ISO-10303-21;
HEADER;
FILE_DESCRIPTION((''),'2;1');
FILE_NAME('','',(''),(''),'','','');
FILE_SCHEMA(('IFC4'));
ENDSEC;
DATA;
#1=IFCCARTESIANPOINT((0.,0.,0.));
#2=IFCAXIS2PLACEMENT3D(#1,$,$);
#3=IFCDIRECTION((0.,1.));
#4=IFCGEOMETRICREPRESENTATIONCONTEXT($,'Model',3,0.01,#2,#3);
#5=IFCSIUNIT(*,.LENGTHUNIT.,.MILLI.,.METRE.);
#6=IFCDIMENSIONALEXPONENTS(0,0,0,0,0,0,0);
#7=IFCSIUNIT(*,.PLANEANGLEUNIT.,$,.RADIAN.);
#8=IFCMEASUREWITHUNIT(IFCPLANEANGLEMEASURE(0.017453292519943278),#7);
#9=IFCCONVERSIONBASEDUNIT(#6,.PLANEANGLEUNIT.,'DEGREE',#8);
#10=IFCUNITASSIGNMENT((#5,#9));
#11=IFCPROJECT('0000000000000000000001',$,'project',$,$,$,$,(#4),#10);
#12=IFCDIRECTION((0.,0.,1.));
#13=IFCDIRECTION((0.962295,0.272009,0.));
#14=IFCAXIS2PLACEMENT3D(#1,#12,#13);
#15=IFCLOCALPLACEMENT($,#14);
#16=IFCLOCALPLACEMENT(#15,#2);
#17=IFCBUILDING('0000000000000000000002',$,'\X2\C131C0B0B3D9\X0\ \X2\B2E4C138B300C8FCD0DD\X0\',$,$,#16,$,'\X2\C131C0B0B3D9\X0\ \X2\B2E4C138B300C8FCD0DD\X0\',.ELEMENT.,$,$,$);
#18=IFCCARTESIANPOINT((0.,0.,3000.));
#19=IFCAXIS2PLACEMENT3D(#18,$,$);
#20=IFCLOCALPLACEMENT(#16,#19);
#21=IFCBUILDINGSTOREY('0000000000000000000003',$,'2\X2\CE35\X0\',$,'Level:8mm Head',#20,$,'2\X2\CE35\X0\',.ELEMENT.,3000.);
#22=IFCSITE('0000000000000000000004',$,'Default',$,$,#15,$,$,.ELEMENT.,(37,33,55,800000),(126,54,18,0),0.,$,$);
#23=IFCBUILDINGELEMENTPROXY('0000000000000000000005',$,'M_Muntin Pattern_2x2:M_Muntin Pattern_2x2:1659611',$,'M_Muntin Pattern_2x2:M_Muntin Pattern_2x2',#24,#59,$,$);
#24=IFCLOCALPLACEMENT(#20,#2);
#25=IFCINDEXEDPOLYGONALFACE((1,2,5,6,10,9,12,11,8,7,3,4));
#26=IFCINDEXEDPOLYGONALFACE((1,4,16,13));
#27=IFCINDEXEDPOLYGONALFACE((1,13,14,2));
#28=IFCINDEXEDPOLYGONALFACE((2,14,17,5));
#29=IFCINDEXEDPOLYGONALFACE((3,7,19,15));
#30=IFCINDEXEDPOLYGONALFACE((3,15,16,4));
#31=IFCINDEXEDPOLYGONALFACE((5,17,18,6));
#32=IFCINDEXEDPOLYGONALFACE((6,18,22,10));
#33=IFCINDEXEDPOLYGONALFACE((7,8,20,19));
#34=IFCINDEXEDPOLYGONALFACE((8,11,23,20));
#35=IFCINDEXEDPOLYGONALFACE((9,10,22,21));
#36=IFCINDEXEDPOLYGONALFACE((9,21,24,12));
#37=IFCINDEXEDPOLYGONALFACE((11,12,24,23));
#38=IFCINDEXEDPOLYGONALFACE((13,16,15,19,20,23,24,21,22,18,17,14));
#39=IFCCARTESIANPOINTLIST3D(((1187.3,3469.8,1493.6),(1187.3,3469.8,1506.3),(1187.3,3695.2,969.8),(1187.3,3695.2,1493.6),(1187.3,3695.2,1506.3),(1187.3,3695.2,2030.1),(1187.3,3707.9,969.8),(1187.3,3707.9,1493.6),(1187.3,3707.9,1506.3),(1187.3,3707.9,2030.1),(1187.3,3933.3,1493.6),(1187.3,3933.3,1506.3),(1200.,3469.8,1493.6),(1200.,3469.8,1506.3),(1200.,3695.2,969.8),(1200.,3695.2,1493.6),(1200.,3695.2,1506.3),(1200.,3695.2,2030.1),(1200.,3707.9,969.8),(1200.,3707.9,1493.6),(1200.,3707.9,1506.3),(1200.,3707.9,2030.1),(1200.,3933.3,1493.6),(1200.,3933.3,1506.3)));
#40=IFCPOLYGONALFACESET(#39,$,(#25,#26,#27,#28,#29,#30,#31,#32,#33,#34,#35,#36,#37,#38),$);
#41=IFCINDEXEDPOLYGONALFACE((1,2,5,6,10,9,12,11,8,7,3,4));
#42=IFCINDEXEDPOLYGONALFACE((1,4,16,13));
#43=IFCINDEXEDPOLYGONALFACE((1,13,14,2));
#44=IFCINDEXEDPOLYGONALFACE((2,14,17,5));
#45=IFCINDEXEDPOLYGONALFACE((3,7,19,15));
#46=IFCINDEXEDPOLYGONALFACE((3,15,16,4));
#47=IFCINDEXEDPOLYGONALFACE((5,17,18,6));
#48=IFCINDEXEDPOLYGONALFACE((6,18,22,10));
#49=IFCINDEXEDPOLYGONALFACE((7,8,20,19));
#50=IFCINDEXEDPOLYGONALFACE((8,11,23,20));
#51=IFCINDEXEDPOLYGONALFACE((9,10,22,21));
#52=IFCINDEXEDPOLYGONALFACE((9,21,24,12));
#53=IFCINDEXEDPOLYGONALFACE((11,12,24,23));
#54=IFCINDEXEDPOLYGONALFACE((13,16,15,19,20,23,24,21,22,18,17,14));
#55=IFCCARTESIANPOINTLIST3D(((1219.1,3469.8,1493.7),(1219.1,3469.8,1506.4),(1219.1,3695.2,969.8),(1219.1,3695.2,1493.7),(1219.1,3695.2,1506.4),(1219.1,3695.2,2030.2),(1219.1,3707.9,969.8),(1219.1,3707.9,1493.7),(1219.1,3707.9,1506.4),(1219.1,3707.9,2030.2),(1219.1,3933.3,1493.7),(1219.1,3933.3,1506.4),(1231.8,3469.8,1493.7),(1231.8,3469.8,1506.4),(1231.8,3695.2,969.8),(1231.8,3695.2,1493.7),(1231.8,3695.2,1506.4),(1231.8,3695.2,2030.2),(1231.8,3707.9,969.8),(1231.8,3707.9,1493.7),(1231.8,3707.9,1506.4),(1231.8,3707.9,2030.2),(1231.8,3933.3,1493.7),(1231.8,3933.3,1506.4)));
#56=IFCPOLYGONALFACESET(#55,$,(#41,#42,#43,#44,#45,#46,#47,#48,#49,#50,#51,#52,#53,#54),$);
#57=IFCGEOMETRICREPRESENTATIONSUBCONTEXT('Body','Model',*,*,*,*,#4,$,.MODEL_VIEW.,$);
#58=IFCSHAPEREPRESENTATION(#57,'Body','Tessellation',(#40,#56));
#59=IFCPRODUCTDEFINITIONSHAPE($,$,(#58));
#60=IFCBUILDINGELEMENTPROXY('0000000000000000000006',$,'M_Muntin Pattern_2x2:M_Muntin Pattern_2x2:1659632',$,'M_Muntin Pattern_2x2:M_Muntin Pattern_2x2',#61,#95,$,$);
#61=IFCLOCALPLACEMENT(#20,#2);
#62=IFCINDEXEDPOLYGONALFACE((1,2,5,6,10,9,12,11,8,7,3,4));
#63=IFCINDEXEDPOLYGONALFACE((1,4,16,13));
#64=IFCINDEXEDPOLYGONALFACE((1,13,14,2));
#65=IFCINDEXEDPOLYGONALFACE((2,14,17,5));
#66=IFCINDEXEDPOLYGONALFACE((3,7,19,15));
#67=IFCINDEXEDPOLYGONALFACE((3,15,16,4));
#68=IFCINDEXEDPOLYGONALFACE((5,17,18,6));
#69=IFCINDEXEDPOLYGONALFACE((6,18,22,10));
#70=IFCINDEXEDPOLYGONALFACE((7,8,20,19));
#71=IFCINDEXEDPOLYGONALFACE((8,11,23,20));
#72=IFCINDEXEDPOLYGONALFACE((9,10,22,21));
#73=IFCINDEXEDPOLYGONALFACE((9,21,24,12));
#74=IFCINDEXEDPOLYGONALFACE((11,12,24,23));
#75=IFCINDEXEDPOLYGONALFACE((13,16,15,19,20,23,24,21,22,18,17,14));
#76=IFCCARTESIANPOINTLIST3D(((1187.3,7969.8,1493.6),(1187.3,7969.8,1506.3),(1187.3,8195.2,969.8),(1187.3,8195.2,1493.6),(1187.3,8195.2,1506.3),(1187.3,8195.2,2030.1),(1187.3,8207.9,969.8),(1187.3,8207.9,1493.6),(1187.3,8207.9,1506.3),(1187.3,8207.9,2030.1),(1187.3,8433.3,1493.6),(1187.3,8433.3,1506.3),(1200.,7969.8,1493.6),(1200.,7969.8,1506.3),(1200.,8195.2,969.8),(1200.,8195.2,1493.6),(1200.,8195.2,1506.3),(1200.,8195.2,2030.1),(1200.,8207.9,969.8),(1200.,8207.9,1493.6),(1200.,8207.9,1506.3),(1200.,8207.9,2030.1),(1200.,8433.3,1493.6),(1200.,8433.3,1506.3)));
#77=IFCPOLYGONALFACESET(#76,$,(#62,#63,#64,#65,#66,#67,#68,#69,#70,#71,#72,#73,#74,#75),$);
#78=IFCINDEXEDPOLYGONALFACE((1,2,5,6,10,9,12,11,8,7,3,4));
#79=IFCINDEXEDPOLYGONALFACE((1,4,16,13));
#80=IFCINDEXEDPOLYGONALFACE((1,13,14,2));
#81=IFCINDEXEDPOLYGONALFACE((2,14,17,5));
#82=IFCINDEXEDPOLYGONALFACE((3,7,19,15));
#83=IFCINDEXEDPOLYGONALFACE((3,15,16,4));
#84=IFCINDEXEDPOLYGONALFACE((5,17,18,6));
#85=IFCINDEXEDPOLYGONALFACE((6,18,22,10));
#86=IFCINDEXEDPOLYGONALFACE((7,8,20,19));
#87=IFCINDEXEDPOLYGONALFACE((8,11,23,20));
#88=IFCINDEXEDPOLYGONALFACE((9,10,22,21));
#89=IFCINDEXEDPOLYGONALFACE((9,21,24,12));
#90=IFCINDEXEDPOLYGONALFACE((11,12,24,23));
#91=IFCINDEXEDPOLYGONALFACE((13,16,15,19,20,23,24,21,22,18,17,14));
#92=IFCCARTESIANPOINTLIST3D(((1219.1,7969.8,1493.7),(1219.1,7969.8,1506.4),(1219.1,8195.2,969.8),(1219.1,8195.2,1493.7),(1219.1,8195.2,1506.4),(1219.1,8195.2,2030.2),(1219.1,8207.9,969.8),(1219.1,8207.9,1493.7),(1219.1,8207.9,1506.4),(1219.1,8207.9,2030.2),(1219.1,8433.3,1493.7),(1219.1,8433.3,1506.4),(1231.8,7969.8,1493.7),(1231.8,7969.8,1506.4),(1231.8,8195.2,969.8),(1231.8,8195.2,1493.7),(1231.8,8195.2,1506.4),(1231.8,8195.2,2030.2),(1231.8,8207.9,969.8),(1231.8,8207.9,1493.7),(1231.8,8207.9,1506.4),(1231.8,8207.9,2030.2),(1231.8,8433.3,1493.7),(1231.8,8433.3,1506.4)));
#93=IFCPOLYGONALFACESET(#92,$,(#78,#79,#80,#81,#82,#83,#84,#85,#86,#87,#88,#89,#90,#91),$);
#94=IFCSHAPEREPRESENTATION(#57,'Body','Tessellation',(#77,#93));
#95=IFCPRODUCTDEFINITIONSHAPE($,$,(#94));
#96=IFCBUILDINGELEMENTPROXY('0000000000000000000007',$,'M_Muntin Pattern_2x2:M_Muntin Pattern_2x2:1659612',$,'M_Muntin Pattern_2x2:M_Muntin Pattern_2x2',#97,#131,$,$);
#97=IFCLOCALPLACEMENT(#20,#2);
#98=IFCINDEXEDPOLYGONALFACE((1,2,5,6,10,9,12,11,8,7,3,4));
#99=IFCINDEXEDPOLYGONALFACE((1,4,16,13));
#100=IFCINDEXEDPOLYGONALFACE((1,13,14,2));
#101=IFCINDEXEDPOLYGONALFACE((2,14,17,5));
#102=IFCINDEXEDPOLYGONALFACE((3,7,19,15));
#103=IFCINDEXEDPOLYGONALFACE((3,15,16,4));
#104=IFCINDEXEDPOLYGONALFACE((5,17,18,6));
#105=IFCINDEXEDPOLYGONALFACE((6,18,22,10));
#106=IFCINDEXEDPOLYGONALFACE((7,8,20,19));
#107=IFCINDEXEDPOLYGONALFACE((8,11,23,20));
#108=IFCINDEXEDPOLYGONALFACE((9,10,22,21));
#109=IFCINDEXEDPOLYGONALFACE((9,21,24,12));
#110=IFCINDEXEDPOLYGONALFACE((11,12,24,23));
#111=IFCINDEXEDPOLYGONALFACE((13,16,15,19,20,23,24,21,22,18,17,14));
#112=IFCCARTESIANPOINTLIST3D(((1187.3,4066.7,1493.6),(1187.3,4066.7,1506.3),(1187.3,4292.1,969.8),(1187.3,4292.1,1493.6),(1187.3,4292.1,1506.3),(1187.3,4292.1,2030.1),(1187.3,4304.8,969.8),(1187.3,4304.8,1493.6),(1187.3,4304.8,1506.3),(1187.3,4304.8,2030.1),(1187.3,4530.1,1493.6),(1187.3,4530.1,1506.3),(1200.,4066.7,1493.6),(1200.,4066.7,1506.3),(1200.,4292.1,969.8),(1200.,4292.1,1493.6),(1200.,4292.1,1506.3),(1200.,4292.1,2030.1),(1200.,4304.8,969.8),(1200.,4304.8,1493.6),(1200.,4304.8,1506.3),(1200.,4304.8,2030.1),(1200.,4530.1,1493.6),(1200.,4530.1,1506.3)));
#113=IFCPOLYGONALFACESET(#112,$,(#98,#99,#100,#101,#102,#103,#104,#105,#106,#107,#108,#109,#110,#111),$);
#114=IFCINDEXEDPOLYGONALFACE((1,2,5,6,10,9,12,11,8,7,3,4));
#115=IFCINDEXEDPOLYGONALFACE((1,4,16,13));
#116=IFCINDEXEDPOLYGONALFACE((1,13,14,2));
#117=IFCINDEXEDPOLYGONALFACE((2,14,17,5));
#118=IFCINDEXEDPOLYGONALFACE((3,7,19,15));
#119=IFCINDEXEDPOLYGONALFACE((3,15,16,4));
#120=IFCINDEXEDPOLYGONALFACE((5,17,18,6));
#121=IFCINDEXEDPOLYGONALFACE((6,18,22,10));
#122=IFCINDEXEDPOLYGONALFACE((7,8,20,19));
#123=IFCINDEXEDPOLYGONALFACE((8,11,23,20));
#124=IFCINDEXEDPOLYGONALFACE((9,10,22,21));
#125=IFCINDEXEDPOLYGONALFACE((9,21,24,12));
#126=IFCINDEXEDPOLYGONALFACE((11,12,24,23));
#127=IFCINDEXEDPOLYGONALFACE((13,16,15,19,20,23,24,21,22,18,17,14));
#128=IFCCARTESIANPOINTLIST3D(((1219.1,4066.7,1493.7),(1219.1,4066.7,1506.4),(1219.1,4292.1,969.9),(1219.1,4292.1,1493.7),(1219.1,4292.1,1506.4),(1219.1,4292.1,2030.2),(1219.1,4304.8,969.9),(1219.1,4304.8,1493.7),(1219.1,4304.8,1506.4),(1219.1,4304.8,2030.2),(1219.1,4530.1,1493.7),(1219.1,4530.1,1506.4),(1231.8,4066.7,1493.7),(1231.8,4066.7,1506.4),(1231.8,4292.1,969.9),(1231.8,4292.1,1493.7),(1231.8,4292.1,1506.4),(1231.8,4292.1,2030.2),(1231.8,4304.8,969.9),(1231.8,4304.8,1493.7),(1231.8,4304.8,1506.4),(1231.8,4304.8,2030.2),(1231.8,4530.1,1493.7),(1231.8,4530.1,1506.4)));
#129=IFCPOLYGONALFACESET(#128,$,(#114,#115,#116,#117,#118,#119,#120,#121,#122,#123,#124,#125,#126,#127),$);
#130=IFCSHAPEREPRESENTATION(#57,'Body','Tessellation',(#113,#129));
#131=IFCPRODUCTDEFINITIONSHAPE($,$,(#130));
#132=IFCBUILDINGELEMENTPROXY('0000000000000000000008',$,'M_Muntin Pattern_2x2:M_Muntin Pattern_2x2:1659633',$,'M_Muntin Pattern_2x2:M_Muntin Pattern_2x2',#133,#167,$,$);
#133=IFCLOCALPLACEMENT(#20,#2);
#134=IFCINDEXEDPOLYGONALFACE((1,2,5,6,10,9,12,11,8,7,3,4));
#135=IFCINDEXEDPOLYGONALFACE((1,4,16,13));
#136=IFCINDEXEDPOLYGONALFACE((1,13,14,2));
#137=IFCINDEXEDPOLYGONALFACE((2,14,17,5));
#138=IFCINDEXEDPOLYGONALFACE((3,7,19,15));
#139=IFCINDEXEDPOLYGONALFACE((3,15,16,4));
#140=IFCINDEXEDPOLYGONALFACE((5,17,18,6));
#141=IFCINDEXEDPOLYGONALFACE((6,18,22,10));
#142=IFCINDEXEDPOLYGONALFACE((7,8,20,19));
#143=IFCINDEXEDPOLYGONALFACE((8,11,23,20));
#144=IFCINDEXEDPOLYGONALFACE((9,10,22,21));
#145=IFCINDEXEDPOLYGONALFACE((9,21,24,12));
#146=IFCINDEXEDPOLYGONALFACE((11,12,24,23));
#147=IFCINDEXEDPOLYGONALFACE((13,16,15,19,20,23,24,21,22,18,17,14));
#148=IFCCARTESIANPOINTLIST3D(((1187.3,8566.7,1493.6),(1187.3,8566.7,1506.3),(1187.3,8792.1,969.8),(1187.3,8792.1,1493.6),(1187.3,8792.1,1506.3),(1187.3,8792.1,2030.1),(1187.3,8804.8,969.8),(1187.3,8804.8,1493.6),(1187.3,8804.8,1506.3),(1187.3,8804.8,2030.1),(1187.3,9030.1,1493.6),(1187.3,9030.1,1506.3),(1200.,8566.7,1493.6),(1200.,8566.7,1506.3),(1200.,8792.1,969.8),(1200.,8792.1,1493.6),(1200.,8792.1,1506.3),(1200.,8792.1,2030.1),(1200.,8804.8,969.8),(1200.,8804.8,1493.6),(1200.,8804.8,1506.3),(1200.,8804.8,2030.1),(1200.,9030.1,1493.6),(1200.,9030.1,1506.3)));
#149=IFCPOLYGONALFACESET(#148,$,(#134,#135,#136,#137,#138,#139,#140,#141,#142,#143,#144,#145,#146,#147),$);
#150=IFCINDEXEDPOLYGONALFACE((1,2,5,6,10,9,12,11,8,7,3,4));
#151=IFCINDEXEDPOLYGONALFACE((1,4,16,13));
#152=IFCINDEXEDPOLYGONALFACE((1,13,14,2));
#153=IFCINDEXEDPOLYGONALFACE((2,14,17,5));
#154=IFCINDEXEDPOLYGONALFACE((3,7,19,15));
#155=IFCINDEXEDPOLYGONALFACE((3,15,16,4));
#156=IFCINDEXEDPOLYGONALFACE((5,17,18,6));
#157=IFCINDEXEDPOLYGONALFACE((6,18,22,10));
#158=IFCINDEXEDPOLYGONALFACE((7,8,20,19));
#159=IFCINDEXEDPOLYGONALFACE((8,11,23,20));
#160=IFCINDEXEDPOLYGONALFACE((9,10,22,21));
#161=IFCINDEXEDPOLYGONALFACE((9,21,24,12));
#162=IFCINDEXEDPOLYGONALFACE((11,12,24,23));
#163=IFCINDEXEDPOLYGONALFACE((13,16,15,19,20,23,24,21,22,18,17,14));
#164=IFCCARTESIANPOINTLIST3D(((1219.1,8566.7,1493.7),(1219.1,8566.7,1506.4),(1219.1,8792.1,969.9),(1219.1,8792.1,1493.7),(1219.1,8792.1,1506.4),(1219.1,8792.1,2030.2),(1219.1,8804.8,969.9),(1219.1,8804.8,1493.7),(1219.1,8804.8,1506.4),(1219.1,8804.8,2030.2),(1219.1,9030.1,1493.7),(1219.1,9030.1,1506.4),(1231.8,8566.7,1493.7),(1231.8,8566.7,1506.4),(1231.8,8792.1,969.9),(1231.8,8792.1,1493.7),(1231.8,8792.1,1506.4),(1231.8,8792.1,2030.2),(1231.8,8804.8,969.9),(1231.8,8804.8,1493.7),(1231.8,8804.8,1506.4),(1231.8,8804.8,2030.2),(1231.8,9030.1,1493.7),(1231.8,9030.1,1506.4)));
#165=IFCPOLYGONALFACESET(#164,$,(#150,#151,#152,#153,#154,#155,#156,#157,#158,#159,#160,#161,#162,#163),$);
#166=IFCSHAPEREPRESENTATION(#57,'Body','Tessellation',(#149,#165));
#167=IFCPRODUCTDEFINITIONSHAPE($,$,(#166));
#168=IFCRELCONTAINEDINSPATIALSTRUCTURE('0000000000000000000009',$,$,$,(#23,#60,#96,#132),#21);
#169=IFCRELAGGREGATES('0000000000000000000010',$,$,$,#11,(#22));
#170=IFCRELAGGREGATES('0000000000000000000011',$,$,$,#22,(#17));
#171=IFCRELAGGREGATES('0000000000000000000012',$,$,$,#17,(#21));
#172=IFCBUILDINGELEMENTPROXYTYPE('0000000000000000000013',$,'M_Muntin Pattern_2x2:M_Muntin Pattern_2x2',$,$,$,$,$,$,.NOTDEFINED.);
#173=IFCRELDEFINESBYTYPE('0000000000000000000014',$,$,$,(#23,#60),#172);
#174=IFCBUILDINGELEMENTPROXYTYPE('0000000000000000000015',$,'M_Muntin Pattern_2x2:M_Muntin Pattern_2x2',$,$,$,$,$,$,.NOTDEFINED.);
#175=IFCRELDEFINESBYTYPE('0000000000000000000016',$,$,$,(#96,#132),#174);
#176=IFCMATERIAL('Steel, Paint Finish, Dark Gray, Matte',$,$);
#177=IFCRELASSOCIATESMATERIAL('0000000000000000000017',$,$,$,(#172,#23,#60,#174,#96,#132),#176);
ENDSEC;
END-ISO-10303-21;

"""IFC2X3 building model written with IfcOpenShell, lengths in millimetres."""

from ifc_helpers import new_model, entity, si_unit, converted_unit, direction, frame, origin, place, context, subcontext, project, spatial, polyline, outline, extrude, source, transform, mapped, material, type_object, type_shapes, element, save


model = new_model("IFC2X3")

# Units and contexts
model_context = context("Model", 3, precision=0.01, world=origin(), true_north=direction((0.0, 1.0)))
body_context = subcontext(model_context, "Body", "Model", "MODEL_VIEW")
ifc_project = project(units=[si_unit("LENGTHUNIT", "METRE", prefix="MILLI"), converted_unit("PLANEANGLEUNIT", "DEGREE", entity("IfcPlaneAngleMeasure", 0.017453292519943278), si_unit("PLANEANGLEUNIT", "RADIAN"), dimensions=[0, 0, 0, 0, 0, 0, 0])], contexts=[model_context])

# Site, building, storey
site_placement = place(None, frame((0.0, 0.0, 0.0), z_axis=(0.0, 0.0, 1.0), x_axis=(0.962295, 0.272009, 0.0)))
site = spatial("IfcSite", under=ifc_project, at=site_placement, Name="Default", CompositionType="ELEMENT", RefLatitude=(37, 33, 55, 800000), RefLongitude=(126, 54, 18, 0), RefElevation=0.0)
building_placement = place(site_placement, origin())
building = spatial("IfcBuilding", under=site, at=building_placement, Name="성산동 다세대주택", LongName="성산동 다세대주택", CompositionType="ELEMENT")
storey_placement = place(building_placement, frame((0.0, 0.0, 3000.0)))
storey = spatial("IfcBuildingStorey", under=building, at=storey_placement, Name="2층", ObjectType="Level:8mm Head", LongName="2층", CompositionType="ELEMENT", Elevation=3000.0)

# Building element proxies
ifc_material_1 = material(Name="Steel, Paint Finish, Dark Gray, Matte")
building_element_proxy_type_1 = type_object("IfcBuildingElementProxyType", Name="M_Muntin Pattern_2x2:M_Muntin Pattern_2x2", PredefinedType="NOTDEFINED", material=ifc_material_1)
shared_shape_1 = source(origin(), body_context, "Body", "SweptSolid", [
    extrude(outline(polyline([(6.4, -6.4), (530.1, -6.4), (530.1, 6.3), (6.4, 6.3), (6.4, 231.7), (-6.3, 231.7), (-6.3, 6.3), (-530.2, 6.3), (-530.2, -6.4), (-6.3, -6.4), (-6.3, -231.7), (6.4, -231.7), (6.4, -6.4)])), frame((0.0, 9.5, 530.1), z_axis=(0.0, 1.0, 0.0), x_axis=(0.0, 0.0, 1.0)), (0.0, 0.0, 1.0), 12.7),
    extrude(outline(polyline([(6.4, -6.4), (530.2, -6.4), (530.2, 6.3), (6.4, 6.3), (6.4, 231.7), (-6.3, 231.7), (-6.3, 6.3), (-530.2, 6.3), (-530.2, -6.4), (-6.3, -6.4), (-6.3, -231.7), (6.4, -231.7), (6.4, -6.4)])), frame((0.0, -22.2, 530.2), z_axis=(0.0, 1.0, 0.0), x_axis=(0.0, 0.0, 1.0)), (0.0, 0.0, 1.0), 12.7),
])
type_shapes(building_element_proxy_type_1, [shared_shape_1])
for number, where, z_axis, x_axis, name in (
    (1, (1209.5, 3701.6, 969.8), (0.0, 0.0, 1.0), (0.0, 1.0, 0.0), "M_Muntin Pattern_2x2:M_Muntin Pattern_2x2:1659611"),
    (2, (1209.5, 8201.6, 969.8), (0.0, 0.0, 1.0), (0.0, 1.0, 0.0), "M_Muntin Pattern_2x2:M_Muntin Pattern_2x2:1659632"),
):
    element("IfcBuildingElementProxy", number, at=place(storey_placement, frame(where, z_axis=z_axis, x_axis=x_axis)), inside=storey, type_object=building_element_proxy_type_1, material=ifc_material_1, Name=name, ObjectType="M_Muntin Pattern_2x2:M_Muntin Pattern_2x2", context=body_context, shape_type="MappedRepresentation", body=[
        mapped(shared_shape_1, transform((0.0, 0.0, 0.0), scale=1.0)),
    ])
building_element_proxy_type_2 = type_object("IfcBuildingElementProxyType", Name="M_Muntin Pattern_2x2:M_Muntin Pattern_2x2", PredefinedType="NOTDEFINED", material=ifc_material_1)
shared_shape_2 = source(origin(), body_context, "Body", "SweptSolid", [
    extrude(outline(polyline([(6.4, -6.4), (530.1, -6.4), (530.1, 6.3), (6.4, 6.3), (6.4, 231.7), (-6.3, 231.7), (-6.3, 6.3), (-530.2, 6.3), (-530.2, -6.4), (-6.3, -6.4), (-6.3, -231.7), (6.4, -231.7), (6.4, -6.4)])), frame((0.0, -22.2, 530.1), z_axis=(0.0, 1.0, 0.0), x_axis=(0.0, 0.0, 1.0)), (0.0, 0.0, 1.0), 12.7),
    extrude(outline(polyline([(6.4, -6.4), (530.2, -6.4), (530.2, 6.3), (6.4, 6.3), (6.4, 231.7), (-6.3, 231.7), (-6.3, 6.3), (-530.2, 6.3), (-530.2, -6.4), (-6.3, -6.4), (-6.3, -231.7), (6.4, -231.7), (6.4, -6.4)])), frame((0.0, 9.5, 530.2), z_axis=(0.0, 1.0, 0.0), x_axis=(0.0, 0.0, 1.0)), (0.0, 0.0, 1.0), 12.7),
])
type_shapes(building_element_proxy_type_2, [shared_shape_2])
for number, where, z_axis, x_axis, name in (
    (3, (1209.5, 4298.4, 969.9), (0.0, 0.0, 1.0), (0.0, -1.0, 0.0), "M_Muntin Pattern_2x2:M_Muntin Pattern_2x2:1659612"),
    (4, (1209.5, 8798.4, 969.9), (0.0, 0.0, 1.0), (0.0, -1.0, 0.0), "M_Muntin Pattern_2x2:M_Muntin Pattern_2x2:1659633"),
):
    element("IfcBuildingElementProxy", number, at=place(storey_placement, frame(where, z_axis=z_axis, x_axis=x_axis)), inside=storey, type_object=building_element_proxy_type_2, material=ifc_material_1, Name=name, ObjectType="M_Muntin Pattern_2x2:M_Muntin Pattern_2x2", context=body_context, shape_type="MappedRepresentation", body=[
        mapped(shared_shape_2, transform((0.0, 0.0, 0.0), scale=1.0)),
    ])

save(model, "model.ifc")
